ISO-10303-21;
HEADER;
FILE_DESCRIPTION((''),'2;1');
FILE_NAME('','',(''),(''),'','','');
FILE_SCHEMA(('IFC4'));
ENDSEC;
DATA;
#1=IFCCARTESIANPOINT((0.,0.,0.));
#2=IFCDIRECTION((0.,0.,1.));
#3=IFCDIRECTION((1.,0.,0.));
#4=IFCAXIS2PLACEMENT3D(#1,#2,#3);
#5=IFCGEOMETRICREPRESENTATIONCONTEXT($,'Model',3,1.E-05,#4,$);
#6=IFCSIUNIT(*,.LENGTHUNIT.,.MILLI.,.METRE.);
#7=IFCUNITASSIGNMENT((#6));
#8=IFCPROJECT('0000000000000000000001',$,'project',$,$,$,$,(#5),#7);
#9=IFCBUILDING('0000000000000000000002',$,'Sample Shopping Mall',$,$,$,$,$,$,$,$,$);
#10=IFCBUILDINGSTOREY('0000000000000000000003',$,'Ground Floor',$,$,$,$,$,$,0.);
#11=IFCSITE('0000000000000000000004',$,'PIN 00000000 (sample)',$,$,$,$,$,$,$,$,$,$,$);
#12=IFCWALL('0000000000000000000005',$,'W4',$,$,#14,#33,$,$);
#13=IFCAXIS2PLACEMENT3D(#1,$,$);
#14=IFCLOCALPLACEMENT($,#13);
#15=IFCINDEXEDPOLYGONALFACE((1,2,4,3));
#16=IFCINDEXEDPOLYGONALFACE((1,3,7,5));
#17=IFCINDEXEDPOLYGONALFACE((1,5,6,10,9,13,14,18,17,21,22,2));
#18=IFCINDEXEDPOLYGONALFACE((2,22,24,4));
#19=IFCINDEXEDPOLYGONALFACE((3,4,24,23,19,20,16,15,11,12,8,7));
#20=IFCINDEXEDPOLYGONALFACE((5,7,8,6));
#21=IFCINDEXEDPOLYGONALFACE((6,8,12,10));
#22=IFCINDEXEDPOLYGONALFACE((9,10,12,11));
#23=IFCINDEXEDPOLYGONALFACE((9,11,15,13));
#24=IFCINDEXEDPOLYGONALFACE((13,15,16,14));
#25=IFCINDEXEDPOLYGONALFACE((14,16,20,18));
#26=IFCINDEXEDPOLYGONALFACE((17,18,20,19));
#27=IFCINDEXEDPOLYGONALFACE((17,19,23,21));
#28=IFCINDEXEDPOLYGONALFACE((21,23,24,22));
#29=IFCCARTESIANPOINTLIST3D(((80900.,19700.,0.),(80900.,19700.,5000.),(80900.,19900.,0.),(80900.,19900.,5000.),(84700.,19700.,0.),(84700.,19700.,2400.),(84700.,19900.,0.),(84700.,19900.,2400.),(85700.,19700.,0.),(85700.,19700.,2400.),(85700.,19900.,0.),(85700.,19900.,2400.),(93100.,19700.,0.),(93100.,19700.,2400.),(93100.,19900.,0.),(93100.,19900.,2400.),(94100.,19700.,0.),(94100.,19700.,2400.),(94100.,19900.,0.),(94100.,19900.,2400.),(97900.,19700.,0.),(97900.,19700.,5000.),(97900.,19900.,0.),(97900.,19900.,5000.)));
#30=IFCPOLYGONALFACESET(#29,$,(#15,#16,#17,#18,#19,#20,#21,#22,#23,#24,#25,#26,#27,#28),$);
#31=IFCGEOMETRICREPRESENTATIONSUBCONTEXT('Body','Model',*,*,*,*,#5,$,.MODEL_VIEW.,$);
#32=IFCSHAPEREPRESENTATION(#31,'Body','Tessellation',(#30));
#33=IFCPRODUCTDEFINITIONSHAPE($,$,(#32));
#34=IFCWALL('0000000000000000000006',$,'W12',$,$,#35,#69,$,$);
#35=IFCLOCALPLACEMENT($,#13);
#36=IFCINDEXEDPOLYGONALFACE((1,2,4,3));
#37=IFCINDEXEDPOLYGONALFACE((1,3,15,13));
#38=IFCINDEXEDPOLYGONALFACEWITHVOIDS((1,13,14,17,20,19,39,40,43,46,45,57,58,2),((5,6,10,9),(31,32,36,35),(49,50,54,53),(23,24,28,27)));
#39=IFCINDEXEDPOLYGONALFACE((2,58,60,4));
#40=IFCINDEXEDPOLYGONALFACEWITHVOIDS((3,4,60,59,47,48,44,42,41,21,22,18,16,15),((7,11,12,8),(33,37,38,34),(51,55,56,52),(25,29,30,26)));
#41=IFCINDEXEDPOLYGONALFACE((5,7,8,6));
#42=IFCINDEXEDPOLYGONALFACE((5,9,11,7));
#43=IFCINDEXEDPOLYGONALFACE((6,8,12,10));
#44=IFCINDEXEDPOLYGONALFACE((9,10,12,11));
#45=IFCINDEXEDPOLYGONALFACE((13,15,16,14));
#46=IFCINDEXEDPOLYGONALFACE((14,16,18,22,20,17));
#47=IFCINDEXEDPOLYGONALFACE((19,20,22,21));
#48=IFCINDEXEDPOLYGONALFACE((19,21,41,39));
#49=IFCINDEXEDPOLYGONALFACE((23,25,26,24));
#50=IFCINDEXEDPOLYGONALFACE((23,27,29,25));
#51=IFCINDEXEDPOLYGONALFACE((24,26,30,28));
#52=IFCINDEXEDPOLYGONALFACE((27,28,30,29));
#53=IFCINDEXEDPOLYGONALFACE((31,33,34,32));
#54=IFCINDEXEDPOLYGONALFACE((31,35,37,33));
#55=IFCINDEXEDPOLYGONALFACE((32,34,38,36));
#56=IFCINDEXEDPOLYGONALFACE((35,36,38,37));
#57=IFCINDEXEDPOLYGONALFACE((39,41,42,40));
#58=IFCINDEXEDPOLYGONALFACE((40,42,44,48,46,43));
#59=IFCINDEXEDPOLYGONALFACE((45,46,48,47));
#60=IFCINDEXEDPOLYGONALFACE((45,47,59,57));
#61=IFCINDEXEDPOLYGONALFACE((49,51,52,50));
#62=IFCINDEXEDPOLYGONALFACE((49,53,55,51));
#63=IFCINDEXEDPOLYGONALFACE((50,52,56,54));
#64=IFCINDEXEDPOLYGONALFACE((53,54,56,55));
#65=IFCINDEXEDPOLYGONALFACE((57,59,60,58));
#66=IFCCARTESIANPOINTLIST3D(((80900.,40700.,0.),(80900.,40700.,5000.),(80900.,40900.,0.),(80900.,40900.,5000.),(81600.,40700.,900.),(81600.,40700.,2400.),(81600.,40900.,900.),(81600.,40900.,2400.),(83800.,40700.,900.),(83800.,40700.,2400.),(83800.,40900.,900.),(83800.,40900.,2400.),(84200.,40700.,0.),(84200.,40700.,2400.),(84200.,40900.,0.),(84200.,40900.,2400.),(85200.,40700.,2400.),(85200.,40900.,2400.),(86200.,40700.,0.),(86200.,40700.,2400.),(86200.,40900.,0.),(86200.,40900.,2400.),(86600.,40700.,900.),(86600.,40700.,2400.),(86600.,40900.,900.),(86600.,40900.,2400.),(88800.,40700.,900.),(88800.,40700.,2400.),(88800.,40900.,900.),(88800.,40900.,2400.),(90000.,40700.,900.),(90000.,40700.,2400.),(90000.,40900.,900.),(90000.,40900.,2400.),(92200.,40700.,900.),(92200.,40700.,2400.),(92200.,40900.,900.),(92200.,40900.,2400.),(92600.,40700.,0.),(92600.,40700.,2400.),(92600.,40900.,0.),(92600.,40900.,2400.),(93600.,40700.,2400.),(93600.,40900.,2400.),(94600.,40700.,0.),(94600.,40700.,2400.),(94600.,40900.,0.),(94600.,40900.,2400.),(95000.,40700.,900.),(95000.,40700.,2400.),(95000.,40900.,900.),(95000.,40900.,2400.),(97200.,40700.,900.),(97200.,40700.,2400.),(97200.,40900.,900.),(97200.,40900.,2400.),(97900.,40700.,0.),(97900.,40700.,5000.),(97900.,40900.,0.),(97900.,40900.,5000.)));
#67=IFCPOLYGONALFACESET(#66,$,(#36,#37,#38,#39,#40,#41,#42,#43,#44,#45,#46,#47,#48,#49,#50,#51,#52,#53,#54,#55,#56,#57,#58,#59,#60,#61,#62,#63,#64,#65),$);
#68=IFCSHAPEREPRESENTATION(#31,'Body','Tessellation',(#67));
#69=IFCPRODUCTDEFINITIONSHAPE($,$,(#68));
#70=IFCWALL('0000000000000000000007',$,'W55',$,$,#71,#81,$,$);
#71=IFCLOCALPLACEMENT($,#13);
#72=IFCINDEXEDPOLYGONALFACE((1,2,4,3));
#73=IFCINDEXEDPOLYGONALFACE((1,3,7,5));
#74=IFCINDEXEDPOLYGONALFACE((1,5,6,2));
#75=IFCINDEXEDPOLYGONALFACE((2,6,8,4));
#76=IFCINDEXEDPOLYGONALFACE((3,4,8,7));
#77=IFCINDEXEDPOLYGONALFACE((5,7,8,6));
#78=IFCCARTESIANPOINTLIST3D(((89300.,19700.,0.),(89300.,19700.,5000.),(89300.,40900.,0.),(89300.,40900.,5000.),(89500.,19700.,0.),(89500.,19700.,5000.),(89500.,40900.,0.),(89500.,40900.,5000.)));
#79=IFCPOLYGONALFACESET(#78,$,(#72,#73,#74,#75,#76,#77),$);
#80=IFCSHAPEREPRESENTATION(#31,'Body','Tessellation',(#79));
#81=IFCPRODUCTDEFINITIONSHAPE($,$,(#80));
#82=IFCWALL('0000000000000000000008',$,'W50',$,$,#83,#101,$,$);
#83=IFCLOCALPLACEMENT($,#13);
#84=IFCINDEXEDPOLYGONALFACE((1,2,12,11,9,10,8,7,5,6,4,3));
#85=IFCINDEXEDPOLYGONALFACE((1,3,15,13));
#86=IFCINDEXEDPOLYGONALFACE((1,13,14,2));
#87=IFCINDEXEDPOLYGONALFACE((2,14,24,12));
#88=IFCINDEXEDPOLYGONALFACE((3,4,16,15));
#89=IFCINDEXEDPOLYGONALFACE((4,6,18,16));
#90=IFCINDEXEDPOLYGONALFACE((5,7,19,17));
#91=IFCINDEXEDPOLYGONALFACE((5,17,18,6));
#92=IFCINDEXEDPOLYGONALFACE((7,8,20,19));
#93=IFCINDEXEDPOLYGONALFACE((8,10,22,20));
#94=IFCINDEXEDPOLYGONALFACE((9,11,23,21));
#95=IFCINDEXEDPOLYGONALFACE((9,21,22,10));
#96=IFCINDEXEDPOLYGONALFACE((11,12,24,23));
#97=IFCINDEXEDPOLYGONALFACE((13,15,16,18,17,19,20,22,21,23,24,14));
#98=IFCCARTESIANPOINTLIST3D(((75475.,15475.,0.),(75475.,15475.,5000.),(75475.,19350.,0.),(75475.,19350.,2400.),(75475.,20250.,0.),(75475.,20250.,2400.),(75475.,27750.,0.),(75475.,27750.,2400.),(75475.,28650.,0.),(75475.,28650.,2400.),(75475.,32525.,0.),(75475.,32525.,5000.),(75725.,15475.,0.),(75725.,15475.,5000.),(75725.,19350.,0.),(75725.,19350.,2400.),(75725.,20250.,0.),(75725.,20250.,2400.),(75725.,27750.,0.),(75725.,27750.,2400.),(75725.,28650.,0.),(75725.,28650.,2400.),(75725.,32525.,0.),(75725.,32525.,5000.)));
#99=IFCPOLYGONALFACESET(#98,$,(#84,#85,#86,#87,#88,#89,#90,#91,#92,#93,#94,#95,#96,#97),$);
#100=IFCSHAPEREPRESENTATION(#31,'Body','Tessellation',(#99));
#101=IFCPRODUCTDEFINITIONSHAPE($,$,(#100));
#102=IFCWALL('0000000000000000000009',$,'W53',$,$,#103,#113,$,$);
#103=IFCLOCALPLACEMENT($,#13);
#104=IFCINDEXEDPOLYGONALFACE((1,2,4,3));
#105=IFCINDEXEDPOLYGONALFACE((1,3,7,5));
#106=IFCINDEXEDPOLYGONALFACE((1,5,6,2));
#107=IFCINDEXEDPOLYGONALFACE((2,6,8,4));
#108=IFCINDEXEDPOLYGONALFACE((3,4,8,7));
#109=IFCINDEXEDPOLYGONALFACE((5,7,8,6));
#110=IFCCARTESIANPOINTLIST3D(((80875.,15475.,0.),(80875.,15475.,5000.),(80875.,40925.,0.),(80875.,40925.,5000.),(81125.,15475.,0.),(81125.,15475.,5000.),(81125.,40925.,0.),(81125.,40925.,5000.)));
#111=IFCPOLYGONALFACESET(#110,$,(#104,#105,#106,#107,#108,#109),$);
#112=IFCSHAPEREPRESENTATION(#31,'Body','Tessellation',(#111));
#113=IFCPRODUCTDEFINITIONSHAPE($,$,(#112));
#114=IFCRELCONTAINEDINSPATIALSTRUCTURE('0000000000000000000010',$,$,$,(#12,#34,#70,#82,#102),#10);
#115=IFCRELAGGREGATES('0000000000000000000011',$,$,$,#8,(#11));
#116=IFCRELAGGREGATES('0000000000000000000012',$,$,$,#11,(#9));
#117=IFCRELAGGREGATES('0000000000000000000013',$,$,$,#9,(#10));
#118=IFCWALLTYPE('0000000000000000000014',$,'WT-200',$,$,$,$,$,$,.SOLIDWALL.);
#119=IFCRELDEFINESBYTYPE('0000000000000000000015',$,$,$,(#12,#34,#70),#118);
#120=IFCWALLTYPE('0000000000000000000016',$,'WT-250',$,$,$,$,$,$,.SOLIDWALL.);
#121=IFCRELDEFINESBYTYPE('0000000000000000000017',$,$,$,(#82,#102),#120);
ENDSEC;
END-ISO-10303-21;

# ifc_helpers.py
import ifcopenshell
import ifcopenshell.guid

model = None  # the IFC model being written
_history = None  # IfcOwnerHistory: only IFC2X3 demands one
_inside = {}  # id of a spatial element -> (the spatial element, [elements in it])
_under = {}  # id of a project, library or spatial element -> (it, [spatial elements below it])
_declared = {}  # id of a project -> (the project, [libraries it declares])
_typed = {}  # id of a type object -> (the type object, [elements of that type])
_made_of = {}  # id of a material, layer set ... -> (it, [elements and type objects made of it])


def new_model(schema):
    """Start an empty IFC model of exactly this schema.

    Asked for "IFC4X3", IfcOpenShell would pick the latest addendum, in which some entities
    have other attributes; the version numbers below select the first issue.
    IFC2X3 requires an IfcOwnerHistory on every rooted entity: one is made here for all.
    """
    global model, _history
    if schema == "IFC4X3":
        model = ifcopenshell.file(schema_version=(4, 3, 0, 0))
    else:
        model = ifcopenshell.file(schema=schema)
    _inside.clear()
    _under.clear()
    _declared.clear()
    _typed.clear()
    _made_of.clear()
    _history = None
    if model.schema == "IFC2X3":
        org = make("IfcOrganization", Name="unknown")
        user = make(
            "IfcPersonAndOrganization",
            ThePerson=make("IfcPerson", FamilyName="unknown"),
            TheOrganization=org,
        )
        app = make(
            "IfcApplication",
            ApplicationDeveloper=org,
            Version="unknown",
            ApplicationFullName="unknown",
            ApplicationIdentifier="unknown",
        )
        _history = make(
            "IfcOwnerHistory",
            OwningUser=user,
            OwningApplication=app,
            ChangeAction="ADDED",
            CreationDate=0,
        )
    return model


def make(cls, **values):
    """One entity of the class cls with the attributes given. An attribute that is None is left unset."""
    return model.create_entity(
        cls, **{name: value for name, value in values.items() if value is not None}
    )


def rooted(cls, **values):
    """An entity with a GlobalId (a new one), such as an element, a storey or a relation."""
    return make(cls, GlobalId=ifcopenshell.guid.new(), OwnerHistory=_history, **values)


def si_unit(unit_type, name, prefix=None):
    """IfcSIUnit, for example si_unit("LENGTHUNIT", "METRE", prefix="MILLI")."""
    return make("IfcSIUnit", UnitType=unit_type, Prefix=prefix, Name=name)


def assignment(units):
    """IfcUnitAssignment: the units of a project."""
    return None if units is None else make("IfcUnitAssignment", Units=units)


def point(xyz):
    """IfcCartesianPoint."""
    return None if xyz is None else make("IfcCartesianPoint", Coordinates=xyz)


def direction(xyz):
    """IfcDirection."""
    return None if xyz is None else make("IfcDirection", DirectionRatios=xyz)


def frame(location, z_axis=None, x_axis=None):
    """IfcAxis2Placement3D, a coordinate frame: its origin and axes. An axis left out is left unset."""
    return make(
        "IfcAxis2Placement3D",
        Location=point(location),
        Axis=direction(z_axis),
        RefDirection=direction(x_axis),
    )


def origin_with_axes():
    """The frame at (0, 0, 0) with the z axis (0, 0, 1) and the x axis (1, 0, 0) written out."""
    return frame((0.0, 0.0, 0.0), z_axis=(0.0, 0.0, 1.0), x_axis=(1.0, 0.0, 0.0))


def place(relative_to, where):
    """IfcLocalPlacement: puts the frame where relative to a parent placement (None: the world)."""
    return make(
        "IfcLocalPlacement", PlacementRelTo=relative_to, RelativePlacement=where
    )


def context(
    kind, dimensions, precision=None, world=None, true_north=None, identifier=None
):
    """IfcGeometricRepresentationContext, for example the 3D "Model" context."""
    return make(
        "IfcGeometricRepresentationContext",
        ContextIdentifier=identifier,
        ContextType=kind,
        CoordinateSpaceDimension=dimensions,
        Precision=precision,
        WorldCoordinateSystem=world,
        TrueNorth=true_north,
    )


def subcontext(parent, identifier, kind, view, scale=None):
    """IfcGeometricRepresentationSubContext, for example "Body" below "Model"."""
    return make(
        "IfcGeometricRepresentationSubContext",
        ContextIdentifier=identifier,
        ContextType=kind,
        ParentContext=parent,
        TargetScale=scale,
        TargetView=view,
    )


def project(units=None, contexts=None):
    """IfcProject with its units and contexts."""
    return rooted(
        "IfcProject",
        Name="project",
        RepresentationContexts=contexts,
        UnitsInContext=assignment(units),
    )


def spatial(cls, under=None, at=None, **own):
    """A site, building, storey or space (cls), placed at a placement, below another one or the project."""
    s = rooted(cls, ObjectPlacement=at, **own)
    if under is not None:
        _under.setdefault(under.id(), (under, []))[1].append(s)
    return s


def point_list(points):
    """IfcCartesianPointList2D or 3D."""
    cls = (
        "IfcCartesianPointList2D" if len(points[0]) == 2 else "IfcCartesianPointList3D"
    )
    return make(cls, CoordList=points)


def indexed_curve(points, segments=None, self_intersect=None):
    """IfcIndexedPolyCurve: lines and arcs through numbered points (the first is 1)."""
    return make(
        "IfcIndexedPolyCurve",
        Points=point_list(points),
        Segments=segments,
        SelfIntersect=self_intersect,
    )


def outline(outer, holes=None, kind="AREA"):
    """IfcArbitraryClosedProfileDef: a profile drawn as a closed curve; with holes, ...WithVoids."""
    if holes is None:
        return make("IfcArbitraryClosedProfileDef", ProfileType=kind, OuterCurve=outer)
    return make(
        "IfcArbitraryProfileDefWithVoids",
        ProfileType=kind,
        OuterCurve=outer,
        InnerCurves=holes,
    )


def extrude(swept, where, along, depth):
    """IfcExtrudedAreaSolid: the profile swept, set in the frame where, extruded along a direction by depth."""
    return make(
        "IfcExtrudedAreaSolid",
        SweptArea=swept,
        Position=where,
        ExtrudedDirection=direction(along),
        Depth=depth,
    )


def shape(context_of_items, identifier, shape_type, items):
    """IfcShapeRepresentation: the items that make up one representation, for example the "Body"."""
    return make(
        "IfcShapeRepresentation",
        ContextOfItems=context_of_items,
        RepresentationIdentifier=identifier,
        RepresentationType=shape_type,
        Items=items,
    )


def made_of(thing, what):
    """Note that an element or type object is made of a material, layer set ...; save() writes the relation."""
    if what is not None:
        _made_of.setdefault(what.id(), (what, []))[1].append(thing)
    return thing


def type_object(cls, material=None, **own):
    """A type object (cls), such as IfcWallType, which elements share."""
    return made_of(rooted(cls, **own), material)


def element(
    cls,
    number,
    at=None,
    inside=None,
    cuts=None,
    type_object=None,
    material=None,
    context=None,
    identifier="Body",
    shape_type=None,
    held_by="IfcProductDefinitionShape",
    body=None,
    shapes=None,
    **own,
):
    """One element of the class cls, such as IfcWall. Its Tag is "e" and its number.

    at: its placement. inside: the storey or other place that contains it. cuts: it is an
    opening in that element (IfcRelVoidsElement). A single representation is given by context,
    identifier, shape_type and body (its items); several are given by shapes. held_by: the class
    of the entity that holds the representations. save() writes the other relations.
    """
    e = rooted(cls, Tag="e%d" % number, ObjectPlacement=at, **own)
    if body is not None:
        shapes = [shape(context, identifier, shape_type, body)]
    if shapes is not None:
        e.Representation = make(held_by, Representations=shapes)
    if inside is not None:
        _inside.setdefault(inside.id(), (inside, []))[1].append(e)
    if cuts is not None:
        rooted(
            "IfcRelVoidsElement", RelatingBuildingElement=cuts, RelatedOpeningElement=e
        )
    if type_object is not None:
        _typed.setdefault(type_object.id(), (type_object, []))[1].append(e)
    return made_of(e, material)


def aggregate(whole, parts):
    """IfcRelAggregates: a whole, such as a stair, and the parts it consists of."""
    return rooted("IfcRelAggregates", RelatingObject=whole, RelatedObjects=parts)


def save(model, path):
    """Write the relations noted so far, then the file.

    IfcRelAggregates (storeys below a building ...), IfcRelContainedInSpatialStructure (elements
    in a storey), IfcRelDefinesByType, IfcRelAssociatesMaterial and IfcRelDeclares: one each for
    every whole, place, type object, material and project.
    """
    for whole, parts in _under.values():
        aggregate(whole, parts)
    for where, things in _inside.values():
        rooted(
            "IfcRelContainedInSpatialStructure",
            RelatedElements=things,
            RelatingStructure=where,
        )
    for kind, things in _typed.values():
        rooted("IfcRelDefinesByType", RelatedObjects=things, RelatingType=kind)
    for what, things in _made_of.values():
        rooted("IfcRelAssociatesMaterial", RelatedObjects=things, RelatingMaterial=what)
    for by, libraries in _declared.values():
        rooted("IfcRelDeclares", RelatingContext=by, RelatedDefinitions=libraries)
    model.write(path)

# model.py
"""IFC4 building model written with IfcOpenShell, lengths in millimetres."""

from ifc_helpers import new_model, si_unit, frame, origin_with_axes, place, context, subcontext, project, spatial, indexed_curve, outline, extrude, type_object, element, save


model = new_model("IFC4")

# Units and contexts
model_context = context("Model", 3, precision=1e-05, world=origin_with_axes())
body_context = subcontext(model_context, "Body", "Model", "MODEL_VIEW")
ifc_project = project(units=[si_unit("LENGTHUNIT", "METRE", prefix="MILLI")], contexts=[model_context])

# Site, building, storey
site = spatial("IfcSite", under=ifc_project, Name="PIN 00000000 (sample)")
building = spatial("IfcBuilding", under=site, Name="Sample Shopping Mall")
storey = spatial("IfcBuildingStorey", under=building, Name="Ground Floor", Elevation=0.0)

# Walls, openings
wall_type_1 = type_object("IfcWallType", Name="WT-200", PredefinedType="SOLIDWALL")
wall_1_placement = place(None, frame((80900.0, 19700.0, 0.0), z_axis=(0.0, 0.0, 1.0), x_axis=(1.0, 0.0, 0.0)))
wall_1 = element("IfcWall", 1, at=wall_1_placement, inside=storey, type_object=wall_type_1, Name="W4", context=body_context, shape_type="SweptSolid", body=[
    extrude(outline(indexed_curve([(0.0, 0.0), (0.0, 200.0), (17000.0, 200.0), (17000.0, 0.0), (0.0, 0.0)], self_intersect=False)), origin_with_axes(), (0.0, 0.0, 1.0), 5000.0),
])
opening_1_placement = place(wall_1_placement, frame((3800.0, -100.0, 0.0), z_axis=(0.0, 0.0, 1.0), x_axis=(1.0, 0.0, 0.0)))
element("IfcOpeningElement", 2, at=opening_1_placement, cuts=wall_1, context=body_context, shape_type="SweptSolid", body=[
    extrude(outline(indexed_curve([(0.0, 0.0), (0.0, 400.0), (1000.0, 400.0), (1000.0, 0.0), (0.0, 0.0)], self_intersect=False)), origin_with_axes(), (0.0, 0.0, 1.0), 2400.0),
])
opening_2_placement = place(wall_1_placement, frame((12200.0, -100.0, 0.0), z_axis=(0.0, 0.0, 1.0), x_axis=(1.0, 0.0, 0.0)))
element("IfcOpeningElement", 3, at=opening_2_placement, cuts=wall_1, context=body_context, shape_type="SweptSolid", body=[
    extrude(outline(indexed_curve([(0.0, 0.0), (0.0, 400.0), (1000.0, 400.0), (1000.0, 0.0), (0.0, 0.0)], self_intersect=False)), origin_with_axes(), (0.0, 0.0, 1.0), 2400.0),
])
wall_2_placement = place(None, frame((80900.0, 40700.0, 0.0), z_axis=(0.0, 0.0, 1.0), x_axis=(1.0, 0.0, 0.0)))
wall_2 = element("IfcWall", 4, at=wall_2_placement, inside=storey, type_object=wall_type_1, Name="W12", context=body_context, shape_type="SweptSolid", body=[
    extrude(outline(indexed_curve([(0.0, 0.0), (0.0, 200.0), (17000.0, 200.0), (17000.0, 0.0), (0.0, 0.0)], self_intersect=False)), origin_with_axes(), (0.0, 0.0, 1.0), 5000.0),
])
opening_3_placement = place(wall_2_placement, frame((3300.0, -100.0, 0.0), z_axis=(0.0, 0.0, 1.0), x_axis=(1.0, 0.0, 0.0)))
element("IfcOpeningElement", 5, at=opening_3_placement, cuts=wall_2, context=body_context, shape_type="SweptSolid", body=[
    extrude(outline(indexed_curve([(0.0, 0.0), (0.0, 400.0), (1000.0, 400.0), (1000.0, 0.0), (0.0, 0.0)], self_intersect=False)), origin_with_axes(), (0.0, 0.0, 1.0), 2400.0),
])
opening_4_placement = place(wall_2_placement, frame((4300.0, -100.0, 0.0), z_axis=(0.0, 0.0, 1.0), x_axis=(1.0, 0.0, 0.0)))
element("IfcOpeningElement", 6, at=opening_4_placement, cuts=wall_2, context=body_context, shape_type="SweptSolid", body=[
    extrude(outline(indexed_curve([(0.0, 0.0), (0.0, 400.0), (1000.0, 400.0), (1000.0, 0.0), (0.0, 0.0)], self_intersect=False)), origin_with_axes(), (0.0, 0.0, 1.0), 2400.0),
])
opening_5_placement = place(wall_2_placement, frame((11700.0, -100.0, 0.0), z_axis=(0.0, 0.0, 1.0), x_axis=(1.0, 0.0, 0.0)))
element("IfcOpeningElement", 7, at=opening_5_placement, cuts=wall_2, context=body_context, shape_type="SweptSolid", body=[
    extrude(outline(indexed_curve([(0.0, 0.0), (0.0, 400.0), (1000.0, 400.0), (1000.0, 0.0), (0.0, 0.0)], self_intersect=False)), origin_with_axes(), (0.0, 0.0, 1.0), 2400.0),
])
opening_6_placement = place(wall_2_placement, frame((12700.0, -100.0, 0.0), z_axis=(0.0, 0.0, 1.0), x_axis=(1.0, 0.0, 0.0)))
element("IfcOpeningElement", 8, at=opening_6_placement, cuts=wall_2, context=body_context, shape_type="SweptSolid", body=[
    extrude(outline(indexed_curve([(0.0, 0.0), (0.0, 400.0), (1000.0, 400.0), (1000.0, 0.0), (0.0, 0.0)], self_intersect=False)), origin_with_axes(), (0.0, 0.0, 1.0), 2400.0),
])
opening_7_placement = place(wall_2_placement, frame((700.0, -100.0, 900.0), z_axis=(0.0, 0.0, 1.0), x_axis=(1.0, 0.0, 0.0)))
element("IfcOpeningElement", 9, at=opening_7_placement, cuts=wall_2, context=body_context, shape_type="SweptSolid", body=[
    extrude(outline(indexed_curve([(0.0, 0.0), (0.0, 400.0), (2200.0, 400.0), (2200.0, 0.0), (0.0, 0.0)], self_intersect=False)), origin_with_axes(), (0.0, 0.0, 1.0), 1500.0),
])
opening_8_placement = place(wall_2_placement, frame((5700.0, -100.0, 900.0), z_axis=(0.0, 0.0, 1.0), x_axis=(1.0, 0.0, 0.0)))
element("IfcOpeningElement", 10, at=opening_8_placement, cuts=wall_2, context=body_context, shape_type="SweptSolid", body=[
    extrude(outline(indexed_curve([(0.0, 0.0), (0.0, 400.0), (2200.0, 400.0), (2200.0, 0.0), (0.0, 0.0)], self_intersect=False)), origin_with_axes(), (0.0, 0.0, 1.0), 1500.0),
])
opening_9_placement = place(wall_2_placement, frame((9100.0, -100.0, 900.0), z_axis=(0.0, 0.0, 1.0), x_axis=(1.0, 0.0, 0.0)))
element("IfcOpeningElement", 11, at=opening_9_placement, cuts=wall_2, context=body_context, shape_type="SweptSolid", body=[
    extrude(outline(indexed_curve([(0.0, 0.0), (0.0, 400.0), (2200.0, 400.0), (2200.0, 0.0), (0.0, 0.0)], self_intersect=False)), origin_with_axes(), (0.0, 0.0, 1.0), 1500.0),
])
opening_10_placement = place(wall_2_placement, frame((14100.0, -100.0, 900.0), z_axis=(0.0, 0.0, 1.0), x_axis=(1.0, 0.0, 0.0)))
element("IfcOpeningElement", 12, at=opening_10_placement, cuts=wall_2, context=body_context, shape_type="SweptSolid", body=[
    extrude(outline(indexed_curve([(0.0, 0.0), (0.0, 400.0), (2200.0, 400.0), (2200.0, 0.0), (0.0, 0.0)], self_intersect=False)), origin_with_axes(), (0.0, 0.0, 1.0), 1500.0),
])

# Wall
wall_3_placement = place(None, frame((89500.0, 19700.0, 0.0), z_axis=(0.0, 0.0, 1.0), x_axis=(0.0, 1.0, 0.0)))
element("IfcWall", 13, at=wall_3_placement, inside=storey, type_object=wall_type_1, Name="W55", context=body_context, shape_type="SweptSolid", body=[
    extrude(outline(indexed_curve([(0.0, 0.0), (0.0, 200.0), (21200.0, 200.0), (21200.0, 0.0), (0.0, 0.0)], self_intersect=False)), origin_with_axes(), (0.0, 0.0, 1.0), 5000.0),
])

# Wall, openings
wall_type_2 = type_object("IfcWallType", Name="WT-250", PredefinedType="SOLIDWALL")
wall_4_placement = place(None, frame((75725.0, 15475.0, 0.0), z_axis=(0.0, 0.0, 1.0), x_axis=(0.0, 1.0, 0.0)))
wall_4 = element("IfcWall", 14, at=wall_4_placement, inside=storey, type_object=wall_type_2, Name="W50", context=body_context, shape_type="SweptSolid", body=[
    extrude(outline(indexed_curve([(0.0, 0.0), (0.0, 250.0), (17050.0, 250.0), (17050.0, 0.0), (0.0, 0.0)], self_intersect=False)), origin_with_axes(), (0.0, 0.0, 1.0), 5000.0),
])
opening_11_placement = place(wall_4_placement, frame((12275.0, -100.0, 0.0), z_axis=(0.0, 0.0, 1.0), x_axis=(1.0, 0.0, 0.0)))
element("IfcOpeningElement", 15, at=opening_11_placement, cuts=wall_4, context=body_context, shape_type="SweptSolid", body=[
    extrude(outline(indexed_curve([(0.0, 0.0), (0.0, 450.0), (900.0, 450.0), (900.0, 0.0), (0.0, 0.0)], self_intersect=False)), origin_with_axes(), (0.0, 0.0, 1.0), 2400.0),
])
opening_12_placement = place(wall_4_placement, frame((3875.0, -100.0, 0.0), z_axis=(0.0, 0.0, 1.0), x_axis=(1.0, 0.0, 0.0)))
element("IfcOpeningElement", 16, at=opening_12_placement, cuts=wall_4, context=body_context, shape_type="SweptSolid", body=[
    extrude(outline(indexed_curve([(0.0, 0.0), (0.0, 450.0), (900.0, 450.0), (900.0, 0.0), (0.0, 0.0)], self_intersect=False)), origin_with_axes(), (0.0, 0.0, 1.0), 2400.0),
])

# Wall
wall_5_placement = place(None, frame((81125.0, 15475.0, 0.0), z_axis=(0.0, 0.0, 1.0), x_axis=(0.0, 1.0, 0.0)))
element("IfcWall", 17, at=wall_5_placement, inside=storey, type_object=wall_type_2, Name="W53", context=body_context, shape_type="SweptSolid", body=[
    extrude(outline(indexed_curve([(0.0, 0.0), (0.0, 250.0), (25450.0, 250.0), (25450.0, 0.0), (0.0, 0.0)], self_intersect=False)), origin_with_axes(), (0.0, 0.0, 1.0), 5000.0),
])

save(model, "model.ifc")
